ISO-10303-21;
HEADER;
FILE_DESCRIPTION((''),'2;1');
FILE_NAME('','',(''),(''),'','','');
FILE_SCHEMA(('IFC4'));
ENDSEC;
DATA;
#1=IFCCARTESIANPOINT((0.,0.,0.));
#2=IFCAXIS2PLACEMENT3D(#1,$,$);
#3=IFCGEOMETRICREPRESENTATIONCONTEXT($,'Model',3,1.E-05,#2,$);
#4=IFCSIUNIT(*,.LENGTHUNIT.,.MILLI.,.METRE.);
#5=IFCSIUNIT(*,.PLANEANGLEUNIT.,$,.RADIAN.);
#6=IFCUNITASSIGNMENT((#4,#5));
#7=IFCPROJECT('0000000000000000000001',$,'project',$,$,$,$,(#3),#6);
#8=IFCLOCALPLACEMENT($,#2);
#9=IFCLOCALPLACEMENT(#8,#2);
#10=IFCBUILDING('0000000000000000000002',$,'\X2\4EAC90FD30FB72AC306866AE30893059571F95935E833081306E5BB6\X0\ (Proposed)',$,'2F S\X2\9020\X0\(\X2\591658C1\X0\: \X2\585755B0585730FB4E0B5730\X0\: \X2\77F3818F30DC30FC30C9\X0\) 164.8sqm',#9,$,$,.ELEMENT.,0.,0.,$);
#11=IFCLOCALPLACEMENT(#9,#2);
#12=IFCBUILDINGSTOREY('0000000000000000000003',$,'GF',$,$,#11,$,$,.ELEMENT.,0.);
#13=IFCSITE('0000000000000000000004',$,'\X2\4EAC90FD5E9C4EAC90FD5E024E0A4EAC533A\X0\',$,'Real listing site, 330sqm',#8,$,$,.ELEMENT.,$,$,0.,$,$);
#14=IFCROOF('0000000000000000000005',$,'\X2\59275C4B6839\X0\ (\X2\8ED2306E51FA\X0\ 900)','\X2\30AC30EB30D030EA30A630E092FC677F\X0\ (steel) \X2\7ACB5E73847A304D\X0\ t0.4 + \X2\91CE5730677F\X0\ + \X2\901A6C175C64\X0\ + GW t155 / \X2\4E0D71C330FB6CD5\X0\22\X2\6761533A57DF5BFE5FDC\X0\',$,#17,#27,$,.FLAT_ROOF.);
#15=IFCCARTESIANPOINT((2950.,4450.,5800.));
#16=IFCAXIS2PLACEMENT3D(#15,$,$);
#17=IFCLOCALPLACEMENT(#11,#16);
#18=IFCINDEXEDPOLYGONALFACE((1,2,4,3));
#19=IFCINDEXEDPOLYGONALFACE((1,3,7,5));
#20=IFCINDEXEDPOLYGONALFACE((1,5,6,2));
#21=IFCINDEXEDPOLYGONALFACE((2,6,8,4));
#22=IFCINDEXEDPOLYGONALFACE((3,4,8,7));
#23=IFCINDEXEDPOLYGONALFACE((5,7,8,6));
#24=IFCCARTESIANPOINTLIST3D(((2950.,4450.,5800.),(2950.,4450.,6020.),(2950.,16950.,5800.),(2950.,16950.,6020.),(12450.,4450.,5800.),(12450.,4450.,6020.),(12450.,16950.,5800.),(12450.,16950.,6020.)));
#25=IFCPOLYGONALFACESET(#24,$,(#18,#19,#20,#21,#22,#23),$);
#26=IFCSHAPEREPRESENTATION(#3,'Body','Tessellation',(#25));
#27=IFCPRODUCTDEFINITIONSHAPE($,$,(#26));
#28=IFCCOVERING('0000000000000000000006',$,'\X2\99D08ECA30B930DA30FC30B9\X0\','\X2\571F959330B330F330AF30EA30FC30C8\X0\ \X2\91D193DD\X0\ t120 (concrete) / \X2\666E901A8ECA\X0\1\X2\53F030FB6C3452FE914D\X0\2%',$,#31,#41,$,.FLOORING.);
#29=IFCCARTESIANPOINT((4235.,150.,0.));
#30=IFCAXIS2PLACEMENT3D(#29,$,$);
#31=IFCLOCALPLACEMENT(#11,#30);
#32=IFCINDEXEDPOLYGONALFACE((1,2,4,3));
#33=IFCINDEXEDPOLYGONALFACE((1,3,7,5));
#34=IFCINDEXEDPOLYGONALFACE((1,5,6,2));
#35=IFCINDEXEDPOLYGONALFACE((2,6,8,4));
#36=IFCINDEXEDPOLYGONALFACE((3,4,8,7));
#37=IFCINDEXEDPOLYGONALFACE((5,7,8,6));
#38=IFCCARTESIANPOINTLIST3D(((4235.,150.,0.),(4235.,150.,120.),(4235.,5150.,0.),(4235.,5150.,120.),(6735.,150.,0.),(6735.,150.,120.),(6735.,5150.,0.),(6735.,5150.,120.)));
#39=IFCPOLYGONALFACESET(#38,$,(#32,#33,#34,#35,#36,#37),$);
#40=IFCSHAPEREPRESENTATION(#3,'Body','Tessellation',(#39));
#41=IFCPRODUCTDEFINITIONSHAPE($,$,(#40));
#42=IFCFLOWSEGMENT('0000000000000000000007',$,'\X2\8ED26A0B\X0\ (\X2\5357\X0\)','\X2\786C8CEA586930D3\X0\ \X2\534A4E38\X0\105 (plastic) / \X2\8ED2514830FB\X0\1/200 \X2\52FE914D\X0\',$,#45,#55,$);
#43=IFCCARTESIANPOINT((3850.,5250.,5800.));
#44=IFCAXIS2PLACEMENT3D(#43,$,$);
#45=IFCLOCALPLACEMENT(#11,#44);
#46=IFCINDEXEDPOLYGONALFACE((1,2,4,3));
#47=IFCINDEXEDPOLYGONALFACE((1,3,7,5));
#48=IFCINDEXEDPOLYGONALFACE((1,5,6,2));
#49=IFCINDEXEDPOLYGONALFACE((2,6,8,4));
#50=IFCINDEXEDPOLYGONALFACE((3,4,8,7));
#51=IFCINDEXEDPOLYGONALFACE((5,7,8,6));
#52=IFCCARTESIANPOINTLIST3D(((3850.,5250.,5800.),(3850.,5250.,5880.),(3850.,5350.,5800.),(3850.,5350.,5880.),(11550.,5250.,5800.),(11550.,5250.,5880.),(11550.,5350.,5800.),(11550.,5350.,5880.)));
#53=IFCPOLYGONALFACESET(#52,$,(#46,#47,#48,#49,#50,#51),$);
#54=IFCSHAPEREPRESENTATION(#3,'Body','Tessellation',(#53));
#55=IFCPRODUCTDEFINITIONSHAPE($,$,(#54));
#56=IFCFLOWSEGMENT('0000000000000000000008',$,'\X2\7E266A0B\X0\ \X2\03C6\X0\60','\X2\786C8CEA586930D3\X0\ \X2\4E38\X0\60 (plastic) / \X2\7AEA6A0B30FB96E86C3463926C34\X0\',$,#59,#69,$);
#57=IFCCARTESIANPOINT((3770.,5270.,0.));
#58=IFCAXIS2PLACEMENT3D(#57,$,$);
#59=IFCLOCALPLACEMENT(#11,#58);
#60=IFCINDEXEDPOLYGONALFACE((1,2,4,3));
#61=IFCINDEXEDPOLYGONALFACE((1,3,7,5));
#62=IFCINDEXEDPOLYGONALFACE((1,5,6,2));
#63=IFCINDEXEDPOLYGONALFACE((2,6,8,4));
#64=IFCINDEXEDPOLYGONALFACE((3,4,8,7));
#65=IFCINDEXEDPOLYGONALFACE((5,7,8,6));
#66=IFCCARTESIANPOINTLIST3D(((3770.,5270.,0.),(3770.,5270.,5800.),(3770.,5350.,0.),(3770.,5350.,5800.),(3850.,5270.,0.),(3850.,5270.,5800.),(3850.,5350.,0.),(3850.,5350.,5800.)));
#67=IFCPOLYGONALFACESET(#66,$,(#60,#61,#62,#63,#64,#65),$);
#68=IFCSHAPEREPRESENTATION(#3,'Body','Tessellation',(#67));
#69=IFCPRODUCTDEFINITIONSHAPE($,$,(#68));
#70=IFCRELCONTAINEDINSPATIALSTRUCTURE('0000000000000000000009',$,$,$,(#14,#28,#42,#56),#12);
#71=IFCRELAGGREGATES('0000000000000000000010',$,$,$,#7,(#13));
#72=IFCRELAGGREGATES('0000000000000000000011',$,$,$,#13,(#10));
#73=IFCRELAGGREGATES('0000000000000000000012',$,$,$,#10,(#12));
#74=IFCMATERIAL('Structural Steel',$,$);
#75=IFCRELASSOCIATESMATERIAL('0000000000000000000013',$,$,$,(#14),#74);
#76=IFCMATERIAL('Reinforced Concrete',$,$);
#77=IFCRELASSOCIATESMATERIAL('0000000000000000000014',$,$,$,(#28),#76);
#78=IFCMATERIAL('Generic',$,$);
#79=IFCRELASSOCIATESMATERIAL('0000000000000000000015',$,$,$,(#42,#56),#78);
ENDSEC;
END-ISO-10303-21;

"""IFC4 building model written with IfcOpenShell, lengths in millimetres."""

from ifc_helpers import new_model, si_unit, frame, frame_2d, origin, place, context, project, spatial, rectangle, extrude, material, element, save


model = new_model("IFC4")

# Units and contexts
model_context = context("Model", 3, precision=1e-05, world=origin())
ifc_project = project(units=[si_unit("LENGTHUNIT", "METRE", prefix="MILLI"), si_unit("PLANEANGLEUNIT", "RADIAN")], contexts=[model_context])

# Site, building, storey
site_placement = place(None, origin())
site = spatial("IfcSite", under=ifc_project, at=site_placement, Name="京都府京都市上京区", ObjectType="Real listing site, 330sqm", CompositionType="ELEMENT", RefElevation=0.0)
building_placement = place(site_placement, origin())
building = spatial("IfcBuilding", under=site, at=building_placement, Name="京都・犬と暮らす土間広めの家 (Proposed)", ObjectType="2F S造(外壁: 塗喰塗・下地: 石膏ボード) 164.8sqm", CompositionType="ELEMENT", ElevationOfRefHeight=0.0, ElevationOfTerrain=0.0)
storey_placement = place(building_placement, origin())
storey = spatial("IfcBuildingStorey", under=building, at=storey_placement, Name="GF", CompositionType="ELEMENT", Elevation=0.0)

# Shared definitions
ifc_material_1 = material(Name="Reinforced Concrete")

# Roof
ifc_material_2 = material(Name="Structural Steel")
roof_placement = place(storey_placement, frame((2950.0, 4450.0, 5800.0)))
element("IfcRoof", 1, at=roof_placement, inside=storey, material=ifc_material_2, Name="大屋根 (軒の出 900)", Description="ガルバリウム鋼板 (steel) 立平葺き t0.4 + 野地板 + 通気層 + GW t155 / 不燃・法22条区域対応", PredefinedType="FLAT_ROOF", context=model_context, shape_type="SweptSolid", body=[
    extrude(rectangle(XDim=9500.0, YDim=12500.0, at=frame_2d((4750.0, 6250.0))), frame((2950.0, 4450.0, 5800.0)), (0.0, 0.0, 1.0), 220.0),
])

# Covering
covering_placement = place(storey_placement, frame((4235.0, 150.0, 0.0)))
element("IfcCovering", 2, at=covering_placement, inside=storey, material=ifc_material_1, Name="駐車スペース", Description="土間コンクリート 金鏝 t120 (concrete) / 普通車1台・水勾配2%", PredefinedType="FLOORING", context=model_context, shape_type="SweptSolid", body=[
    extrude(rectangle(XDim=2500.0, YDim=5000.0, at=frame_2d((1250.0, 2500.0))), frame((4235.0, 150.0, 0.0)), (0.0, 0.0, 1.0), 120.0),
])

# Flow segments
ifc_material_3 = material(Name="Generic")
flow_segment_1_placement = place(storey_placement, frame((3850.0, 5250.0, 5800.0)))
element("IfcFlowSegment", 3, at=flow_segment_1_placement, inside=storey, material=ifc_material_3, Name="軒樋 (南)", Description="硬質塩ビ 半丸105 (plastic) / 軒先・1/200 勾配", context=model_context, shape_type="SweptSolid", body=[
    extrude(rectangle(XDim=7700.0, YDim=100.0, at=frame_2d((3850.0, 50.0))), frame((3850.0, 5250.0, 5800.0)), (0.0, 0.0, 1.0), 80.0),
])
flow_segment_2_placement = place(storey_placement, frame((3770.0, 5270.0, 0.0)))
element("IfcFlowSegment", 4, at=flow_segment_2_placement, inside=storey, material=ifc_material_3, Name="縦樋 φ60", Description="硬質塩ビ 丸60 (plastic) / 竪樋・雨水排水", context=model_context, shape_type="SweptSolid", body=[
    extrude(rectangle(XDim=80.0, YDim=80.0, at=frame_2d((40.0, 40.0))), frame((3770.0, 5270.0, 0.0)), (0.0, 0.0, 1.0), 5800.0),
])

save(model, "model.ifc")
